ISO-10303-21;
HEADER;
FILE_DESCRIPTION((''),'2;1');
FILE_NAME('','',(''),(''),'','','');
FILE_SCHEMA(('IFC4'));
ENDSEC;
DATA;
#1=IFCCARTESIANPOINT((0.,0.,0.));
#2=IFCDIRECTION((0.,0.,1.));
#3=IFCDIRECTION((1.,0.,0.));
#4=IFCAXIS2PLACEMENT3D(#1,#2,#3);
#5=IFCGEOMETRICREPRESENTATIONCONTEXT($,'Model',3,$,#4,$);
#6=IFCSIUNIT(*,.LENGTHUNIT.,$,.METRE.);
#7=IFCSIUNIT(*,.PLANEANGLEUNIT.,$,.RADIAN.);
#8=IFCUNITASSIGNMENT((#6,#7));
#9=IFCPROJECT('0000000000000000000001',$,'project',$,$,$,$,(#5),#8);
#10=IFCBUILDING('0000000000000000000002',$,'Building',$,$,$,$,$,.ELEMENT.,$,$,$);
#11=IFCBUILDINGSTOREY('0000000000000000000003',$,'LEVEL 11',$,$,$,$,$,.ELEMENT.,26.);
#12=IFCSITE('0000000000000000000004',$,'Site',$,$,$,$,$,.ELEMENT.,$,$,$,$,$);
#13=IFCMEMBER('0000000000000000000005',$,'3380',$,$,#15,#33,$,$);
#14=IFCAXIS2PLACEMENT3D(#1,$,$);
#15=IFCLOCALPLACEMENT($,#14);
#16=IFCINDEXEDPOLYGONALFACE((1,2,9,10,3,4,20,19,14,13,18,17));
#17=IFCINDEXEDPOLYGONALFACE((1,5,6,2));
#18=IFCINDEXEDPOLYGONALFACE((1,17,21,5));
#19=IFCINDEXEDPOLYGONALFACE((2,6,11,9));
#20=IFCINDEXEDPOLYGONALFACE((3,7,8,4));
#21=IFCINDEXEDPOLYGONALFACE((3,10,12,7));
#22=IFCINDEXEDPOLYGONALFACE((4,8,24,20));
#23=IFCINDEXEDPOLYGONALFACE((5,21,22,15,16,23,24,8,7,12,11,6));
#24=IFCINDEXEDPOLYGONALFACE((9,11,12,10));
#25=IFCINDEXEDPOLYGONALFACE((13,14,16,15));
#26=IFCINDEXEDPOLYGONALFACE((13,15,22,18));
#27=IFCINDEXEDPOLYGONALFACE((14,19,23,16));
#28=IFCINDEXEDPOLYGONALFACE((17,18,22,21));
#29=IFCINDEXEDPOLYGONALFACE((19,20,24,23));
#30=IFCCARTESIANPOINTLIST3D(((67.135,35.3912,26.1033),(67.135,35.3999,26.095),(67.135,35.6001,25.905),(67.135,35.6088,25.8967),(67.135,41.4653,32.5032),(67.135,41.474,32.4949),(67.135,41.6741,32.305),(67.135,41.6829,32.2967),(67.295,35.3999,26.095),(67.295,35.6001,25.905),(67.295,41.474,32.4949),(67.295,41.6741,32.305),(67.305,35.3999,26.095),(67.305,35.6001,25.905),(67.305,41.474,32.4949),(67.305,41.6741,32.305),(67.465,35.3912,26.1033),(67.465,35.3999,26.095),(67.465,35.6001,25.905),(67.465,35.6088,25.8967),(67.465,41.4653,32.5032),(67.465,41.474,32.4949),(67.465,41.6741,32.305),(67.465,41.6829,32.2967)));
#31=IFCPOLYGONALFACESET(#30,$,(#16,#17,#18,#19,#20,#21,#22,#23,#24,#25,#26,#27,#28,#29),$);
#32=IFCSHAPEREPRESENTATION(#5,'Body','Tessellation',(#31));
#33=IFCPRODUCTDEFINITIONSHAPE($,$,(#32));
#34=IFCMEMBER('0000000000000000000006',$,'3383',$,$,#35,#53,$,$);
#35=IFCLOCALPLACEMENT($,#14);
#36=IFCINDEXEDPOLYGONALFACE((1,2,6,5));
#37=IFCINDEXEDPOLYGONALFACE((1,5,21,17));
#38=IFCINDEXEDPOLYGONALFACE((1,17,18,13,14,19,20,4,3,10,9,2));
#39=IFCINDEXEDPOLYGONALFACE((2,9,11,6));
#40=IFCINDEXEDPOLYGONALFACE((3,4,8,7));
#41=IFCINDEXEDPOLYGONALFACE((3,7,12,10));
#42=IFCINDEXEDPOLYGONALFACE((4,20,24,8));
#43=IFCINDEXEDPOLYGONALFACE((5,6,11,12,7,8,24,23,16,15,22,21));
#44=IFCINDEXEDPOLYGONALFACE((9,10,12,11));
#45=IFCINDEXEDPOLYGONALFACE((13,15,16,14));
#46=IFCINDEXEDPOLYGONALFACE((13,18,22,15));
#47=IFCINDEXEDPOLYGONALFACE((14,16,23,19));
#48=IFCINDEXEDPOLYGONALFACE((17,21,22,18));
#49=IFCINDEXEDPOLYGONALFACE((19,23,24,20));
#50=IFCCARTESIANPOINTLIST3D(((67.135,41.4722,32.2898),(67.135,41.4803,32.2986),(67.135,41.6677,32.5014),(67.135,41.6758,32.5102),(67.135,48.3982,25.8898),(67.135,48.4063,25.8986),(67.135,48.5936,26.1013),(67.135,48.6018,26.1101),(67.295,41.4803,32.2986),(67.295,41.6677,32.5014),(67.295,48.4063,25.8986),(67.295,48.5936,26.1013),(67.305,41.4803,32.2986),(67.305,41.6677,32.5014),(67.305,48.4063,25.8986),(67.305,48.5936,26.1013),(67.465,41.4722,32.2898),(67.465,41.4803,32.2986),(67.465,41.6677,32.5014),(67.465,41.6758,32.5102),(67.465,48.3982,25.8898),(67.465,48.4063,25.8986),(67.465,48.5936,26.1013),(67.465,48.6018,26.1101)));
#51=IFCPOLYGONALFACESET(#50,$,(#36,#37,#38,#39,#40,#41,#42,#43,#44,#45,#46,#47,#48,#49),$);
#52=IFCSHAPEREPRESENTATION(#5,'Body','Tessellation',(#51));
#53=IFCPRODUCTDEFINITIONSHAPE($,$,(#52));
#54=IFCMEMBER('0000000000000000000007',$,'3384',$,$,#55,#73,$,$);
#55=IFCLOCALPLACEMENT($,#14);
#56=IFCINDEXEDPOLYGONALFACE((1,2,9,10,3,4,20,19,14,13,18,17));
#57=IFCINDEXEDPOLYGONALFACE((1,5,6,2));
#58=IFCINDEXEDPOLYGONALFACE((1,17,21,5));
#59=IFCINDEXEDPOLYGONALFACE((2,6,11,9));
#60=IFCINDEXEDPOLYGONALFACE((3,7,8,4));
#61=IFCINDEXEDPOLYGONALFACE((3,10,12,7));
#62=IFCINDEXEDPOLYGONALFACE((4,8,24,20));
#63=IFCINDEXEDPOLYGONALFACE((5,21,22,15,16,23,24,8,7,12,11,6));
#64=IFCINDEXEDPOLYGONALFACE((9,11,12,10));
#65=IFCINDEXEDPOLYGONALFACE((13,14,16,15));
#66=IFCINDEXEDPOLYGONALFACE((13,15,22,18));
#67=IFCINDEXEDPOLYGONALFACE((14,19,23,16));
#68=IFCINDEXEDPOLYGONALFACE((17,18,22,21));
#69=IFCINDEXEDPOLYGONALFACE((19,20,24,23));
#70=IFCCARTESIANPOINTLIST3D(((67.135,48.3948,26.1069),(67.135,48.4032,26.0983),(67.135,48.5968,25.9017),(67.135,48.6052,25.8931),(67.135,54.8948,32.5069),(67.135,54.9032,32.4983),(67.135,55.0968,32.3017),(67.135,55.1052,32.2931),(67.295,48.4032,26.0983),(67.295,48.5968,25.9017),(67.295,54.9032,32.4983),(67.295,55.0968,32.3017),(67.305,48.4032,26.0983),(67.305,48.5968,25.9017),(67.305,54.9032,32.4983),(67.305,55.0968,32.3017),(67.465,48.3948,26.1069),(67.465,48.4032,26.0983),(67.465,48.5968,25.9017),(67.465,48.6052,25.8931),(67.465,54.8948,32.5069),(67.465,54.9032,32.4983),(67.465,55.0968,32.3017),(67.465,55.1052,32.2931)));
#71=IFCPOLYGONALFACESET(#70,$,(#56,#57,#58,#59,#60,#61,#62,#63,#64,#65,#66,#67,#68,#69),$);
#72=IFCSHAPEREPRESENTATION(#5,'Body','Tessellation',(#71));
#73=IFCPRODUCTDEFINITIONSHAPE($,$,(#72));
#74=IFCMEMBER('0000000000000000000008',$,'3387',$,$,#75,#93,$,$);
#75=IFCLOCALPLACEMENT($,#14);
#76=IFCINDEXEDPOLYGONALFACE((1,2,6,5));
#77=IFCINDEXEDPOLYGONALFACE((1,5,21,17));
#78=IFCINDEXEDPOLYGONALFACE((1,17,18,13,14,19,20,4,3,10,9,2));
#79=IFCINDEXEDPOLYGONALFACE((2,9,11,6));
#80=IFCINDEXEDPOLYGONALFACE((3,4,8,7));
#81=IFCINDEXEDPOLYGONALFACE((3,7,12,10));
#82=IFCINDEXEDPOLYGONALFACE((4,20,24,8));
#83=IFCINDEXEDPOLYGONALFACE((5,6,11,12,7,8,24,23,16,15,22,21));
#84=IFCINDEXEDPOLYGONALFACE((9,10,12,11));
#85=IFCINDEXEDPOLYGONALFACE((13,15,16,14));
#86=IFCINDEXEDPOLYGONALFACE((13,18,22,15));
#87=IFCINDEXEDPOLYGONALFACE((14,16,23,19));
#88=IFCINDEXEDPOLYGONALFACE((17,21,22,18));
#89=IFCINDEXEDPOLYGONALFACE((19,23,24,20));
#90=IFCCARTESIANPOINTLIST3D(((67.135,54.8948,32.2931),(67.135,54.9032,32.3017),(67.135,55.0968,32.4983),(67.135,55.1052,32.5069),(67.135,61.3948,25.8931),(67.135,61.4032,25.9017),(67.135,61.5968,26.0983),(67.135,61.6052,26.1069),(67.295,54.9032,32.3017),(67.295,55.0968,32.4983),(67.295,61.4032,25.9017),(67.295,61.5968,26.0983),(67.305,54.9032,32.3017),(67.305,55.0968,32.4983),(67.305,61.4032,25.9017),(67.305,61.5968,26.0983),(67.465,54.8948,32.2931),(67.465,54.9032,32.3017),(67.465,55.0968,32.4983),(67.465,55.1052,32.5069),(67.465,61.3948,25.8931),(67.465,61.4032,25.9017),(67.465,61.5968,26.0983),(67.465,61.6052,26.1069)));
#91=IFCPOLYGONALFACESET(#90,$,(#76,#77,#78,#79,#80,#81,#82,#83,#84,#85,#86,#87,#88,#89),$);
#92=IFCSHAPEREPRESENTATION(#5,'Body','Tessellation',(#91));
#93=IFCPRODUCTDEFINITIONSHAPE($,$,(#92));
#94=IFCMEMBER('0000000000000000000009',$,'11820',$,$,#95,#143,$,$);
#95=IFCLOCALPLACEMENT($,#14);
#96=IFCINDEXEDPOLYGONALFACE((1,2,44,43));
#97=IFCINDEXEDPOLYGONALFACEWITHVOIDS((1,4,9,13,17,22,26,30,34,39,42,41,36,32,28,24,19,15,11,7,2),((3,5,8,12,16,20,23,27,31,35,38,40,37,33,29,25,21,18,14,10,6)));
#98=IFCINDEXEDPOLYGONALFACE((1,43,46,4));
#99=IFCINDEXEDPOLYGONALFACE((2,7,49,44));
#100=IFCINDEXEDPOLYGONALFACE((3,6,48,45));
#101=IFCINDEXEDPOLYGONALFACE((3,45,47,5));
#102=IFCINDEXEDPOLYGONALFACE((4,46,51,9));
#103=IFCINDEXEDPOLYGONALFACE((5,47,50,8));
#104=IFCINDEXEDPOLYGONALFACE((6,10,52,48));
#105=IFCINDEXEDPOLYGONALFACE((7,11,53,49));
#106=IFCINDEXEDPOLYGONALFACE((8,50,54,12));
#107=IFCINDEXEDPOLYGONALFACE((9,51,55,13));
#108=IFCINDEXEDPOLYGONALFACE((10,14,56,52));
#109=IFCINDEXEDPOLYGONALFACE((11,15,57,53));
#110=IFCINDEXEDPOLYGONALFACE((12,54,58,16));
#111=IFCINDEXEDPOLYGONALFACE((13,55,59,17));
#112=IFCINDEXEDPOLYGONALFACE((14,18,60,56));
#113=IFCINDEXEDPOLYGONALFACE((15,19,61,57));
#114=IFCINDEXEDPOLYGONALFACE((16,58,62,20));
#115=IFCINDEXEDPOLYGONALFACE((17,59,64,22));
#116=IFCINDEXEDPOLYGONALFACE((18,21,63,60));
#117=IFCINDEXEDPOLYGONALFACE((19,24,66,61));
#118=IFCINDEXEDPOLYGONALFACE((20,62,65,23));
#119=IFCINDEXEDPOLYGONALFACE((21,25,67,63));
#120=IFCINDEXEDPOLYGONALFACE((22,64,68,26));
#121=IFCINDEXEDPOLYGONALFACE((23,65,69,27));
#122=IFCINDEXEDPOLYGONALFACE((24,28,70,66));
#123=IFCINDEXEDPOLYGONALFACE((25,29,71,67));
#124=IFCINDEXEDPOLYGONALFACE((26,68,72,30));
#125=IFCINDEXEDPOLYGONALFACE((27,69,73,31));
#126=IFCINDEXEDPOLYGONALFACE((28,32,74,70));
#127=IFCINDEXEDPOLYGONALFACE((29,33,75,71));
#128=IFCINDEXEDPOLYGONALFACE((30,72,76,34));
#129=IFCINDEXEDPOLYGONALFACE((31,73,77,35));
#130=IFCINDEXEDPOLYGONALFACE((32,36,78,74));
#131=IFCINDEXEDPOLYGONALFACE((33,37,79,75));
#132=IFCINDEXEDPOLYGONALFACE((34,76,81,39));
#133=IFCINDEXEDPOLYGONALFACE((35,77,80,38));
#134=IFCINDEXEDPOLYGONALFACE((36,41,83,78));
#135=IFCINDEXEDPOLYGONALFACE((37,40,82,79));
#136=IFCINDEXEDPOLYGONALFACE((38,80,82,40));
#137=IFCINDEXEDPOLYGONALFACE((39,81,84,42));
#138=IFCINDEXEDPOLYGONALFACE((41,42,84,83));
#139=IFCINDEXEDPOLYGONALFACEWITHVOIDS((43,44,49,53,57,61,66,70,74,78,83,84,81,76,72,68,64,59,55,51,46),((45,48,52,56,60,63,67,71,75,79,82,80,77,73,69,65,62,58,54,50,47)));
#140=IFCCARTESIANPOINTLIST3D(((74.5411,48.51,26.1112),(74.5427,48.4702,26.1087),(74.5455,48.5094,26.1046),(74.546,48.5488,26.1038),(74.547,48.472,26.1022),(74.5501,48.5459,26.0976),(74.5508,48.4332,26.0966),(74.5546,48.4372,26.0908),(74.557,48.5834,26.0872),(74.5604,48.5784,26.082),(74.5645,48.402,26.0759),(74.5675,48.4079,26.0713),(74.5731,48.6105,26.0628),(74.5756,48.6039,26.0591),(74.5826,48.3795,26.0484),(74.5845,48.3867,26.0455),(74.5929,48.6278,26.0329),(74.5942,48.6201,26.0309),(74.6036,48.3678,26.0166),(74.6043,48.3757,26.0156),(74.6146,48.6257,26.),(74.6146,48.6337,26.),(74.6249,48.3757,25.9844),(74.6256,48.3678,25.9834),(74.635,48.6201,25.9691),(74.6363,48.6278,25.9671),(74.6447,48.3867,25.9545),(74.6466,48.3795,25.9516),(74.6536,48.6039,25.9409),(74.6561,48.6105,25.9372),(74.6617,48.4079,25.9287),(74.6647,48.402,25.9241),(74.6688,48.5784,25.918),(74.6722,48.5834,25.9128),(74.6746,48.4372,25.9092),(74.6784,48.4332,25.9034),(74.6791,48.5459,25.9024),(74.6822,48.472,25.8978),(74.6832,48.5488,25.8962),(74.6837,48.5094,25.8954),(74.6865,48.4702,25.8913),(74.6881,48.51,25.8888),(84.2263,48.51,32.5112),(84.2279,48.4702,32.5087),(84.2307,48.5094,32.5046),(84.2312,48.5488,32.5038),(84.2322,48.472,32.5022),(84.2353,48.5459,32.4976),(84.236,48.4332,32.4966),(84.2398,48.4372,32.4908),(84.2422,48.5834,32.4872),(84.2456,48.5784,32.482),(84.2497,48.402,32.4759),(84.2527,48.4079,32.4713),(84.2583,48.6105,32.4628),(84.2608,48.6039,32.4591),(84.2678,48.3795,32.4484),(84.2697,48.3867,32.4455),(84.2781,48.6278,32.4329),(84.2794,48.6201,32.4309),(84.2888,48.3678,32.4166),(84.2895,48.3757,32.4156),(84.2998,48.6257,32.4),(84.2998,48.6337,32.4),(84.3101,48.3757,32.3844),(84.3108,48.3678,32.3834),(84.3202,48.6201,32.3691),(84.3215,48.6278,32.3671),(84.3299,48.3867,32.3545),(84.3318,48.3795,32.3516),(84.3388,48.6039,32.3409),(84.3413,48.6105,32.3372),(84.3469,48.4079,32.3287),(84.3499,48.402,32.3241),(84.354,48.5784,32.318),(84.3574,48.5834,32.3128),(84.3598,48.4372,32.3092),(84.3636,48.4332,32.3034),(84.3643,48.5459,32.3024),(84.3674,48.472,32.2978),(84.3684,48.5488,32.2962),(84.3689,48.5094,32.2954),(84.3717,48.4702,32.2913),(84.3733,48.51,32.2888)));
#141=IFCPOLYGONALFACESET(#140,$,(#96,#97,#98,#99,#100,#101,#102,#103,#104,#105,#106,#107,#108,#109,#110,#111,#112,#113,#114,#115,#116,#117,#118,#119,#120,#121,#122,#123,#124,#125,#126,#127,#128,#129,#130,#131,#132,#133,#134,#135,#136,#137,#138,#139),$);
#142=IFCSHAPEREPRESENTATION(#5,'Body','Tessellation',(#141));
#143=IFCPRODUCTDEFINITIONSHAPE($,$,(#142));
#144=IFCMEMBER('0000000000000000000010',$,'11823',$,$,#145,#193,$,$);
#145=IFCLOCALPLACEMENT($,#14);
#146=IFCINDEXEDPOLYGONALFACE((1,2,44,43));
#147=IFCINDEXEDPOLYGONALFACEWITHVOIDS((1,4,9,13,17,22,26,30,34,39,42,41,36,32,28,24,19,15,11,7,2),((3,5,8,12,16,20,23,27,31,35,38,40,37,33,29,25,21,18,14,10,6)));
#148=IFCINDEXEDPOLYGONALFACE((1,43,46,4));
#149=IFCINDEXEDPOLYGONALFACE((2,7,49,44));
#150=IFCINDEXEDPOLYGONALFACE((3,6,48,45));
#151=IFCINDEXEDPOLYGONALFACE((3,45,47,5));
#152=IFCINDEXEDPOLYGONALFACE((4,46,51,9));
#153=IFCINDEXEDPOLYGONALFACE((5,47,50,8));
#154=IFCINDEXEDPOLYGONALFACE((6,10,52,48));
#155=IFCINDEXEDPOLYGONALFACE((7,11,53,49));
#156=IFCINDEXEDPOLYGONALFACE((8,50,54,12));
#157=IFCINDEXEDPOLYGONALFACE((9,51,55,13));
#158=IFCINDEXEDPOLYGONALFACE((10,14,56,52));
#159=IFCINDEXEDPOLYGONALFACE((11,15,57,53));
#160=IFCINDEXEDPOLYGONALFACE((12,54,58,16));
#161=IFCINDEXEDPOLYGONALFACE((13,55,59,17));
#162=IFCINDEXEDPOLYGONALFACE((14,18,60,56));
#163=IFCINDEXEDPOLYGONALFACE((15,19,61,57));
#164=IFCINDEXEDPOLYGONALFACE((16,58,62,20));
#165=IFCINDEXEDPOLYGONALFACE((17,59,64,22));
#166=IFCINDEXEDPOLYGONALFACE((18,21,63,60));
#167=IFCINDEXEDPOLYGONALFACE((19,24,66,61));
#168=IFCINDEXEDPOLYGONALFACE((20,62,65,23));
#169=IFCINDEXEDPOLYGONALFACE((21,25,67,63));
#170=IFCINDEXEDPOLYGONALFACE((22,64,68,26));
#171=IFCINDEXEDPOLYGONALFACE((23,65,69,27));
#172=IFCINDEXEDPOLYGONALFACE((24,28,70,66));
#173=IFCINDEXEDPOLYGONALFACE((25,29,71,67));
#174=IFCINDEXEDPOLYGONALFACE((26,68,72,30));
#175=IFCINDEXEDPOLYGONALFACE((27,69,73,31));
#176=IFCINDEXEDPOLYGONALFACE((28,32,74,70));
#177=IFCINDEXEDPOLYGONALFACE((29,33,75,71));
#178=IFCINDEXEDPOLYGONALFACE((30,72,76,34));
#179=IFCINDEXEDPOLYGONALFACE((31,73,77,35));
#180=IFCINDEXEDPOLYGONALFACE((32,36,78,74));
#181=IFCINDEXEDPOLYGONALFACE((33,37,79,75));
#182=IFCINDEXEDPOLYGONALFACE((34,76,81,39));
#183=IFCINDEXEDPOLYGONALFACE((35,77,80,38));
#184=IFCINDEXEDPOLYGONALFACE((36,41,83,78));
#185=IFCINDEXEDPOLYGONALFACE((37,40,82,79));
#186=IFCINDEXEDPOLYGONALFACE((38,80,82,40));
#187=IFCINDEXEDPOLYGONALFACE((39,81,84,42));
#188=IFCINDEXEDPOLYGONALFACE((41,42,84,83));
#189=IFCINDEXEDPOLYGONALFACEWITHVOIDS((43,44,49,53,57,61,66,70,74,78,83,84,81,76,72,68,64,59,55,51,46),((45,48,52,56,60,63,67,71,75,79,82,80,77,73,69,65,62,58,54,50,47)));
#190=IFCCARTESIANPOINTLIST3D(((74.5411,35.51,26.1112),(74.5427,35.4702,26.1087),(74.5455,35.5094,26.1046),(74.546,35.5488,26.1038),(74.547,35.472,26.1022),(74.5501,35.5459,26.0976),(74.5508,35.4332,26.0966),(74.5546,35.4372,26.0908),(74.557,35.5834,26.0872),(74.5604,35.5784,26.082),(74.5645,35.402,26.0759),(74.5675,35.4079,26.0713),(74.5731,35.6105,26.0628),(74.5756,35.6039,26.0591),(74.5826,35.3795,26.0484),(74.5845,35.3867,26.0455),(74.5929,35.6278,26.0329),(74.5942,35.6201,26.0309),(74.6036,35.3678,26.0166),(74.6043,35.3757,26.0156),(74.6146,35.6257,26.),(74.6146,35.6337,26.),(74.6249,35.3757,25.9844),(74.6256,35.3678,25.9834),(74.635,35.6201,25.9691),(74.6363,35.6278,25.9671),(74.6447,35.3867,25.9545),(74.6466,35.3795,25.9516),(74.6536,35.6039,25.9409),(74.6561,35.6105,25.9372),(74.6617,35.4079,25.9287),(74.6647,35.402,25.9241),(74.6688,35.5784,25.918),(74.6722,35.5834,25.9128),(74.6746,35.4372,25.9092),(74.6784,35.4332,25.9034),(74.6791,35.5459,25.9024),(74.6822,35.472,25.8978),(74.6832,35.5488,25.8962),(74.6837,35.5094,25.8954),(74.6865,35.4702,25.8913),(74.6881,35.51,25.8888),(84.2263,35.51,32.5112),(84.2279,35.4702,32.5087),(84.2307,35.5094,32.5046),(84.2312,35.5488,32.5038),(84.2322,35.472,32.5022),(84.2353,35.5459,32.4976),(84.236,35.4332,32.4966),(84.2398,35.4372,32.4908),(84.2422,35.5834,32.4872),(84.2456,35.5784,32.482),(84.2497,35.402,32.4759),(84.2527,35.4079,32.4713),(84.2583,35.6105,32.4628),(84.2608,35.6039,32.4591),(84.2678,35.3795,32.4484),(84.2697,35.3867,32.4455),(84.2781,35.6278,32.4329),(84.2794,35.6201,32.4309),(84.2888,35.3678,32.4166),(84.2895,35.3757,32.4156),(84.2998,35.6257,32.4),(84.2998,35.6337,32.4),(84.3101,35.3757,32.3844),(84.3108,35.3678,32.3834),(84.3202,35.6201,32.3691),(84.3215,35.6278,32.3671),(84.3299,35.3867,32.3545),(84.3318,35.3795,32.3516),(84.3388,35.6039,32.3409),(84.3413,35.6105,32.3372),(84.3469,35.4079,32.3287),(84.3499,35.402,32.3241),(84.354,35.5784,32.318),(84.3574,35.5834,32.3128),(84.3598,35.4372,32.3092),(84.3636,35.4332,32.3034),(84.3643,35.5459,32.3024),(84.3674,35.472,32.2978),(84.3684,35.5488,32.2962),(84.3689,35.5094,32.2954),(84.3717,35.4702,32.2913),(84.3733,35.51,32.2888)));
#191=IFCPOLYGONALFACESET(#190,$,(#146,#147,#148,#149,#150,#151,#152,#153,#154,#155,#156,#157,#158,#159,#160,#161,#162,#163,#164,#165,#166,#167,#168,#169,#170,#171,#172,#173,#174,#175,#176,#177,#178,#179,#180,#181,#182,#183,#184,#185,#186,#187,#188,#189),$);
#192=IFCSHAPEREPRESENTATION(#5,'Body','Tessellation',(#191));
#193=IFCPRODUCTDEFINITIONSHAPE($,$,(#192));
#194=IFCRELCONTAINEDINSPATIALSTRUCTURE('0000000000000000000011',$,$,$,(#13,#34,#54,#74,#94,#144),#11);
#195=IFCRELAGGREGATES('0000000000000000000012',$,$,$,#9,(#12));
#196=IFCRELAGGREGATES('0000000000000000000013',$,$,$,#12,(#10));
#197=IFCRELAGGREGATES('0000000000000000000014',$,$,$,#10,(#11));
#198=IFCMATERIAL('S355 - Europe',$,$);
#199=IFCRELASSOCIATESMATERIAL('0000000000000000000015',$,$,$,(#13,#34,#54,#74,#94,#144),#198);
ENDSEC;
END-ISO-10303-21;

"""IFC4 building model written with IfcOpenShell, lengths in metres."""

from ifc_helpers import new_model, si_unit, frame, origin_with_axes, origin_2d_with_axis, place, context, project, spatial, hollow_circle, i_section, extrude, material, material_profile, profile_set, profile_usage, element, save


model = new_model("IFC4")

# Units and contexts
model_context = context("Model", 3, world=origin_with_axes())
ifc_project = project(units=[si_unit("LENGTHUNIT", "METRE"), si_unit("PLANEANGLEUNIT", "RADIAN")], contexts=[model_context])

# Site, building, storey
site = spatial("IfcSite", under=ifc_project, Name="Site", CompositionType="ELEMENT")
building = spatial("IfcBuilding", under=site, Name="Building", CompositionType="ELEMENT")
storey = spatial("IfcBuildingStorey", under=building, Name="LEVEL 11", CompositionType="ELEMENT", Elevation=26.0)

# Shared definitions
ifc_material = material(Name="S355 - Europe")

# Members
ifc_material_profile_1 = material_profile(ifc_material, i_section(OverallWidth=0.33, OverallDepth=0.3, WebThickness=0.01, FlangeThickness=0.012, at=origin_2d_with_axis()))
ifc_profile_set_1 = profile_set([ifc_material_profile_1])
ifc_profile_usage_1 = profile_usage(ifc_profile_set_1, cardinal=10)
member_1_placement = place(None, frame((67.3, 35.5, 26.0), z_axis=(0.0, 0.688398, 0.725333), x_axis=(-1.0, 0.0, 0.0)))
element("IfcMember", 1, at=member_1_placement, inside=storey, material=ifc_profile_usage_1, Name="3380", context=model_context, shape_type="SweptSolid", body=[
    extrude(i_section(OverallWidth=0.33, OverallDepth=0.3, WebThickness=0.01, FlangeThickness=0.012, at=origin_2d_with_axis()), origin_with_axes(), (0.0, 0.0, 1.0), 8.8235),
])
ifc_material_profile_2 = material_profile(ifc_material, i_section(OverallWidth=0.33, OverallDepth=0.3, WebThickness=0.01, FlangeThickness=0.012, at=origin_2d_with_axis()))
ifc_profile_set_2 = profile_set([ifc_material_profile_2])
ifc_profile_usage_2 = profile_usage(ifc_profile_set_2, cardinal=10)
member_2_placement = place(None, frame((67.3, 41.574, 32.4), z_axis=(0.0, 0.734441, -0.678673), x_axis=(-1.0, 0.0, 0.0)))
element("IfcMember", 2, at=member_2_placement, inside=storey, material=ifc_profile_usage_2, Name="3383", context=model_context, shape_type="SweptSolid", body=[
    extrude(i_section(OverallWidth=0.33, OverallDepth=0.3, WebThickness=0.01, FlangeThickness=0.012, at=origin_2d_with_axis()), origin_with_axes(), (0.0, 0.0, 1.0), 9.4302),
])
ifc_material_profile_3 = material_profile(ifc_material, i_section(OverallWidth=0.33, OverallDepth=0.3, WebThickness=0.01, FlangeThickness=0.012, at=origin_2d_with_axis()))
ifc_profile_set_3 = profile_set([ifc_material_profile_3])
ifc_profile_usage_3 = profile_usage(ifc_profile_set_3, cardinal=10)
member_3_placement = place(None, frame((67.3, 48.5, 26.0), z_axis=(0.0, 0.712567, 0.701604), x_axis=(-1.0, 0.0, 0.0)))
element("IfcMember", 3, at=member_3_placement, inside=storey, material=ifc_profile_usage_3, Name="3384", context=model_context, shape_type="SweptSolid", body=[
    extrude(i_section(OverallWidth=0.33, OverallDepth=0.3, WebThickness=0.01, FlangeThickness=0.012, at=origin_2d_with_axis()), origin_with_axes(), (0.0, 0.0, 1.0), 9.122),
])
ifc_material_profile_4 = material_profile(ifc_material, i_section(OverallWidth=0.33, OverallDepth=0.3, WebThickness=0.01, FlangeThickness=0.012, at=origin_2d_with_axis()))
ifc_profile_set_4 = profile_set([ifc_material_profile_4])
ifc_profile_usage_4 = profile_usage(ifc_profile_set_4, cardinal=10)
member_4_placement = place(None, frame((67.3, 55.0, 32.4), z_axis=(0.0, 0.712567, -0.701604), x_axis=(-1.0, 0.0, 0.0)))
element("IfcMember", 4, at=member_4_placement, inside=storey, material=ifc_profile_usage_4, Name="3387", context=model_context, shape_type="SweptSolid", body=[
    extrude(i_section(OverallWidth=0.33, OverallDepth=0.3, WebThickness=0.01, FlangeThickness=0.012, at=origin_2d_with_axis()), origin_with_axes(), (0.0, 0.0, 1.0), 9.122),
])
ifc_material_profile_5 = material_profile(ifc_material, hollow_circle(Radius=0.1337, WallThickness=0.008, at=origin_2d_with_axis()))
ifc_profile_set_5 = profile_set([ifc_material_profile_5])
ifc_profile_usage_5 = profile_usage(ifc_profile_set_5, cardinal=10)
member_5_placement = place(None, frame((74.6146, 48.5, 26.0), z_axis=(0.834302, 0.0, 0.551308), x_axis=(0.0, 1.0, 0.0)))
element("IfcMember", 5, at=member_5_placement, inside=storey, material=ifc_profile_usage_5, Name="11820", context=model_context, shape_type="SweptSolid", body=[
    extrude(hollow_circle(Radius=0.1337, WallThickness=0.008, at=origin_2d_with_axis()), origin_with_axes(), (0.0, 0.0, 1.0), 11.6088),
])
ifc_material_profile_6 = material_profile(ifc_material, hollow_circle(Radius=0.1337, WallThickness=0.008, at=origin_2d_with_axis()))
ifc_profile_set_6 = profile_set([ifc_material_profile_6])
ifc_profile_usage_6 = profile_usage(ifc_profile_set_6, cardinal=10)
member_6_placement = place(None, frame((74.6146, 35.5, 26.0), z_axis=(0.834302, 0.0, 0.551308), x_axis=(0.0, 1.0, 0.0)))
element("IfcMember", 6, at=member_6_placement, inside=storey, material=ifc_profile_usage_6, Name="11823", context=model_context, shape_type="SweptSolid", body=[
    extrude(hollow_circle(Radius=0.1337, WallThickness=0.008, at=origin_2d_with_axis()), origin_with_axes(), (0.0, 0.0, 1.0), 11.6088),
])

save(model, "model.ifc")
